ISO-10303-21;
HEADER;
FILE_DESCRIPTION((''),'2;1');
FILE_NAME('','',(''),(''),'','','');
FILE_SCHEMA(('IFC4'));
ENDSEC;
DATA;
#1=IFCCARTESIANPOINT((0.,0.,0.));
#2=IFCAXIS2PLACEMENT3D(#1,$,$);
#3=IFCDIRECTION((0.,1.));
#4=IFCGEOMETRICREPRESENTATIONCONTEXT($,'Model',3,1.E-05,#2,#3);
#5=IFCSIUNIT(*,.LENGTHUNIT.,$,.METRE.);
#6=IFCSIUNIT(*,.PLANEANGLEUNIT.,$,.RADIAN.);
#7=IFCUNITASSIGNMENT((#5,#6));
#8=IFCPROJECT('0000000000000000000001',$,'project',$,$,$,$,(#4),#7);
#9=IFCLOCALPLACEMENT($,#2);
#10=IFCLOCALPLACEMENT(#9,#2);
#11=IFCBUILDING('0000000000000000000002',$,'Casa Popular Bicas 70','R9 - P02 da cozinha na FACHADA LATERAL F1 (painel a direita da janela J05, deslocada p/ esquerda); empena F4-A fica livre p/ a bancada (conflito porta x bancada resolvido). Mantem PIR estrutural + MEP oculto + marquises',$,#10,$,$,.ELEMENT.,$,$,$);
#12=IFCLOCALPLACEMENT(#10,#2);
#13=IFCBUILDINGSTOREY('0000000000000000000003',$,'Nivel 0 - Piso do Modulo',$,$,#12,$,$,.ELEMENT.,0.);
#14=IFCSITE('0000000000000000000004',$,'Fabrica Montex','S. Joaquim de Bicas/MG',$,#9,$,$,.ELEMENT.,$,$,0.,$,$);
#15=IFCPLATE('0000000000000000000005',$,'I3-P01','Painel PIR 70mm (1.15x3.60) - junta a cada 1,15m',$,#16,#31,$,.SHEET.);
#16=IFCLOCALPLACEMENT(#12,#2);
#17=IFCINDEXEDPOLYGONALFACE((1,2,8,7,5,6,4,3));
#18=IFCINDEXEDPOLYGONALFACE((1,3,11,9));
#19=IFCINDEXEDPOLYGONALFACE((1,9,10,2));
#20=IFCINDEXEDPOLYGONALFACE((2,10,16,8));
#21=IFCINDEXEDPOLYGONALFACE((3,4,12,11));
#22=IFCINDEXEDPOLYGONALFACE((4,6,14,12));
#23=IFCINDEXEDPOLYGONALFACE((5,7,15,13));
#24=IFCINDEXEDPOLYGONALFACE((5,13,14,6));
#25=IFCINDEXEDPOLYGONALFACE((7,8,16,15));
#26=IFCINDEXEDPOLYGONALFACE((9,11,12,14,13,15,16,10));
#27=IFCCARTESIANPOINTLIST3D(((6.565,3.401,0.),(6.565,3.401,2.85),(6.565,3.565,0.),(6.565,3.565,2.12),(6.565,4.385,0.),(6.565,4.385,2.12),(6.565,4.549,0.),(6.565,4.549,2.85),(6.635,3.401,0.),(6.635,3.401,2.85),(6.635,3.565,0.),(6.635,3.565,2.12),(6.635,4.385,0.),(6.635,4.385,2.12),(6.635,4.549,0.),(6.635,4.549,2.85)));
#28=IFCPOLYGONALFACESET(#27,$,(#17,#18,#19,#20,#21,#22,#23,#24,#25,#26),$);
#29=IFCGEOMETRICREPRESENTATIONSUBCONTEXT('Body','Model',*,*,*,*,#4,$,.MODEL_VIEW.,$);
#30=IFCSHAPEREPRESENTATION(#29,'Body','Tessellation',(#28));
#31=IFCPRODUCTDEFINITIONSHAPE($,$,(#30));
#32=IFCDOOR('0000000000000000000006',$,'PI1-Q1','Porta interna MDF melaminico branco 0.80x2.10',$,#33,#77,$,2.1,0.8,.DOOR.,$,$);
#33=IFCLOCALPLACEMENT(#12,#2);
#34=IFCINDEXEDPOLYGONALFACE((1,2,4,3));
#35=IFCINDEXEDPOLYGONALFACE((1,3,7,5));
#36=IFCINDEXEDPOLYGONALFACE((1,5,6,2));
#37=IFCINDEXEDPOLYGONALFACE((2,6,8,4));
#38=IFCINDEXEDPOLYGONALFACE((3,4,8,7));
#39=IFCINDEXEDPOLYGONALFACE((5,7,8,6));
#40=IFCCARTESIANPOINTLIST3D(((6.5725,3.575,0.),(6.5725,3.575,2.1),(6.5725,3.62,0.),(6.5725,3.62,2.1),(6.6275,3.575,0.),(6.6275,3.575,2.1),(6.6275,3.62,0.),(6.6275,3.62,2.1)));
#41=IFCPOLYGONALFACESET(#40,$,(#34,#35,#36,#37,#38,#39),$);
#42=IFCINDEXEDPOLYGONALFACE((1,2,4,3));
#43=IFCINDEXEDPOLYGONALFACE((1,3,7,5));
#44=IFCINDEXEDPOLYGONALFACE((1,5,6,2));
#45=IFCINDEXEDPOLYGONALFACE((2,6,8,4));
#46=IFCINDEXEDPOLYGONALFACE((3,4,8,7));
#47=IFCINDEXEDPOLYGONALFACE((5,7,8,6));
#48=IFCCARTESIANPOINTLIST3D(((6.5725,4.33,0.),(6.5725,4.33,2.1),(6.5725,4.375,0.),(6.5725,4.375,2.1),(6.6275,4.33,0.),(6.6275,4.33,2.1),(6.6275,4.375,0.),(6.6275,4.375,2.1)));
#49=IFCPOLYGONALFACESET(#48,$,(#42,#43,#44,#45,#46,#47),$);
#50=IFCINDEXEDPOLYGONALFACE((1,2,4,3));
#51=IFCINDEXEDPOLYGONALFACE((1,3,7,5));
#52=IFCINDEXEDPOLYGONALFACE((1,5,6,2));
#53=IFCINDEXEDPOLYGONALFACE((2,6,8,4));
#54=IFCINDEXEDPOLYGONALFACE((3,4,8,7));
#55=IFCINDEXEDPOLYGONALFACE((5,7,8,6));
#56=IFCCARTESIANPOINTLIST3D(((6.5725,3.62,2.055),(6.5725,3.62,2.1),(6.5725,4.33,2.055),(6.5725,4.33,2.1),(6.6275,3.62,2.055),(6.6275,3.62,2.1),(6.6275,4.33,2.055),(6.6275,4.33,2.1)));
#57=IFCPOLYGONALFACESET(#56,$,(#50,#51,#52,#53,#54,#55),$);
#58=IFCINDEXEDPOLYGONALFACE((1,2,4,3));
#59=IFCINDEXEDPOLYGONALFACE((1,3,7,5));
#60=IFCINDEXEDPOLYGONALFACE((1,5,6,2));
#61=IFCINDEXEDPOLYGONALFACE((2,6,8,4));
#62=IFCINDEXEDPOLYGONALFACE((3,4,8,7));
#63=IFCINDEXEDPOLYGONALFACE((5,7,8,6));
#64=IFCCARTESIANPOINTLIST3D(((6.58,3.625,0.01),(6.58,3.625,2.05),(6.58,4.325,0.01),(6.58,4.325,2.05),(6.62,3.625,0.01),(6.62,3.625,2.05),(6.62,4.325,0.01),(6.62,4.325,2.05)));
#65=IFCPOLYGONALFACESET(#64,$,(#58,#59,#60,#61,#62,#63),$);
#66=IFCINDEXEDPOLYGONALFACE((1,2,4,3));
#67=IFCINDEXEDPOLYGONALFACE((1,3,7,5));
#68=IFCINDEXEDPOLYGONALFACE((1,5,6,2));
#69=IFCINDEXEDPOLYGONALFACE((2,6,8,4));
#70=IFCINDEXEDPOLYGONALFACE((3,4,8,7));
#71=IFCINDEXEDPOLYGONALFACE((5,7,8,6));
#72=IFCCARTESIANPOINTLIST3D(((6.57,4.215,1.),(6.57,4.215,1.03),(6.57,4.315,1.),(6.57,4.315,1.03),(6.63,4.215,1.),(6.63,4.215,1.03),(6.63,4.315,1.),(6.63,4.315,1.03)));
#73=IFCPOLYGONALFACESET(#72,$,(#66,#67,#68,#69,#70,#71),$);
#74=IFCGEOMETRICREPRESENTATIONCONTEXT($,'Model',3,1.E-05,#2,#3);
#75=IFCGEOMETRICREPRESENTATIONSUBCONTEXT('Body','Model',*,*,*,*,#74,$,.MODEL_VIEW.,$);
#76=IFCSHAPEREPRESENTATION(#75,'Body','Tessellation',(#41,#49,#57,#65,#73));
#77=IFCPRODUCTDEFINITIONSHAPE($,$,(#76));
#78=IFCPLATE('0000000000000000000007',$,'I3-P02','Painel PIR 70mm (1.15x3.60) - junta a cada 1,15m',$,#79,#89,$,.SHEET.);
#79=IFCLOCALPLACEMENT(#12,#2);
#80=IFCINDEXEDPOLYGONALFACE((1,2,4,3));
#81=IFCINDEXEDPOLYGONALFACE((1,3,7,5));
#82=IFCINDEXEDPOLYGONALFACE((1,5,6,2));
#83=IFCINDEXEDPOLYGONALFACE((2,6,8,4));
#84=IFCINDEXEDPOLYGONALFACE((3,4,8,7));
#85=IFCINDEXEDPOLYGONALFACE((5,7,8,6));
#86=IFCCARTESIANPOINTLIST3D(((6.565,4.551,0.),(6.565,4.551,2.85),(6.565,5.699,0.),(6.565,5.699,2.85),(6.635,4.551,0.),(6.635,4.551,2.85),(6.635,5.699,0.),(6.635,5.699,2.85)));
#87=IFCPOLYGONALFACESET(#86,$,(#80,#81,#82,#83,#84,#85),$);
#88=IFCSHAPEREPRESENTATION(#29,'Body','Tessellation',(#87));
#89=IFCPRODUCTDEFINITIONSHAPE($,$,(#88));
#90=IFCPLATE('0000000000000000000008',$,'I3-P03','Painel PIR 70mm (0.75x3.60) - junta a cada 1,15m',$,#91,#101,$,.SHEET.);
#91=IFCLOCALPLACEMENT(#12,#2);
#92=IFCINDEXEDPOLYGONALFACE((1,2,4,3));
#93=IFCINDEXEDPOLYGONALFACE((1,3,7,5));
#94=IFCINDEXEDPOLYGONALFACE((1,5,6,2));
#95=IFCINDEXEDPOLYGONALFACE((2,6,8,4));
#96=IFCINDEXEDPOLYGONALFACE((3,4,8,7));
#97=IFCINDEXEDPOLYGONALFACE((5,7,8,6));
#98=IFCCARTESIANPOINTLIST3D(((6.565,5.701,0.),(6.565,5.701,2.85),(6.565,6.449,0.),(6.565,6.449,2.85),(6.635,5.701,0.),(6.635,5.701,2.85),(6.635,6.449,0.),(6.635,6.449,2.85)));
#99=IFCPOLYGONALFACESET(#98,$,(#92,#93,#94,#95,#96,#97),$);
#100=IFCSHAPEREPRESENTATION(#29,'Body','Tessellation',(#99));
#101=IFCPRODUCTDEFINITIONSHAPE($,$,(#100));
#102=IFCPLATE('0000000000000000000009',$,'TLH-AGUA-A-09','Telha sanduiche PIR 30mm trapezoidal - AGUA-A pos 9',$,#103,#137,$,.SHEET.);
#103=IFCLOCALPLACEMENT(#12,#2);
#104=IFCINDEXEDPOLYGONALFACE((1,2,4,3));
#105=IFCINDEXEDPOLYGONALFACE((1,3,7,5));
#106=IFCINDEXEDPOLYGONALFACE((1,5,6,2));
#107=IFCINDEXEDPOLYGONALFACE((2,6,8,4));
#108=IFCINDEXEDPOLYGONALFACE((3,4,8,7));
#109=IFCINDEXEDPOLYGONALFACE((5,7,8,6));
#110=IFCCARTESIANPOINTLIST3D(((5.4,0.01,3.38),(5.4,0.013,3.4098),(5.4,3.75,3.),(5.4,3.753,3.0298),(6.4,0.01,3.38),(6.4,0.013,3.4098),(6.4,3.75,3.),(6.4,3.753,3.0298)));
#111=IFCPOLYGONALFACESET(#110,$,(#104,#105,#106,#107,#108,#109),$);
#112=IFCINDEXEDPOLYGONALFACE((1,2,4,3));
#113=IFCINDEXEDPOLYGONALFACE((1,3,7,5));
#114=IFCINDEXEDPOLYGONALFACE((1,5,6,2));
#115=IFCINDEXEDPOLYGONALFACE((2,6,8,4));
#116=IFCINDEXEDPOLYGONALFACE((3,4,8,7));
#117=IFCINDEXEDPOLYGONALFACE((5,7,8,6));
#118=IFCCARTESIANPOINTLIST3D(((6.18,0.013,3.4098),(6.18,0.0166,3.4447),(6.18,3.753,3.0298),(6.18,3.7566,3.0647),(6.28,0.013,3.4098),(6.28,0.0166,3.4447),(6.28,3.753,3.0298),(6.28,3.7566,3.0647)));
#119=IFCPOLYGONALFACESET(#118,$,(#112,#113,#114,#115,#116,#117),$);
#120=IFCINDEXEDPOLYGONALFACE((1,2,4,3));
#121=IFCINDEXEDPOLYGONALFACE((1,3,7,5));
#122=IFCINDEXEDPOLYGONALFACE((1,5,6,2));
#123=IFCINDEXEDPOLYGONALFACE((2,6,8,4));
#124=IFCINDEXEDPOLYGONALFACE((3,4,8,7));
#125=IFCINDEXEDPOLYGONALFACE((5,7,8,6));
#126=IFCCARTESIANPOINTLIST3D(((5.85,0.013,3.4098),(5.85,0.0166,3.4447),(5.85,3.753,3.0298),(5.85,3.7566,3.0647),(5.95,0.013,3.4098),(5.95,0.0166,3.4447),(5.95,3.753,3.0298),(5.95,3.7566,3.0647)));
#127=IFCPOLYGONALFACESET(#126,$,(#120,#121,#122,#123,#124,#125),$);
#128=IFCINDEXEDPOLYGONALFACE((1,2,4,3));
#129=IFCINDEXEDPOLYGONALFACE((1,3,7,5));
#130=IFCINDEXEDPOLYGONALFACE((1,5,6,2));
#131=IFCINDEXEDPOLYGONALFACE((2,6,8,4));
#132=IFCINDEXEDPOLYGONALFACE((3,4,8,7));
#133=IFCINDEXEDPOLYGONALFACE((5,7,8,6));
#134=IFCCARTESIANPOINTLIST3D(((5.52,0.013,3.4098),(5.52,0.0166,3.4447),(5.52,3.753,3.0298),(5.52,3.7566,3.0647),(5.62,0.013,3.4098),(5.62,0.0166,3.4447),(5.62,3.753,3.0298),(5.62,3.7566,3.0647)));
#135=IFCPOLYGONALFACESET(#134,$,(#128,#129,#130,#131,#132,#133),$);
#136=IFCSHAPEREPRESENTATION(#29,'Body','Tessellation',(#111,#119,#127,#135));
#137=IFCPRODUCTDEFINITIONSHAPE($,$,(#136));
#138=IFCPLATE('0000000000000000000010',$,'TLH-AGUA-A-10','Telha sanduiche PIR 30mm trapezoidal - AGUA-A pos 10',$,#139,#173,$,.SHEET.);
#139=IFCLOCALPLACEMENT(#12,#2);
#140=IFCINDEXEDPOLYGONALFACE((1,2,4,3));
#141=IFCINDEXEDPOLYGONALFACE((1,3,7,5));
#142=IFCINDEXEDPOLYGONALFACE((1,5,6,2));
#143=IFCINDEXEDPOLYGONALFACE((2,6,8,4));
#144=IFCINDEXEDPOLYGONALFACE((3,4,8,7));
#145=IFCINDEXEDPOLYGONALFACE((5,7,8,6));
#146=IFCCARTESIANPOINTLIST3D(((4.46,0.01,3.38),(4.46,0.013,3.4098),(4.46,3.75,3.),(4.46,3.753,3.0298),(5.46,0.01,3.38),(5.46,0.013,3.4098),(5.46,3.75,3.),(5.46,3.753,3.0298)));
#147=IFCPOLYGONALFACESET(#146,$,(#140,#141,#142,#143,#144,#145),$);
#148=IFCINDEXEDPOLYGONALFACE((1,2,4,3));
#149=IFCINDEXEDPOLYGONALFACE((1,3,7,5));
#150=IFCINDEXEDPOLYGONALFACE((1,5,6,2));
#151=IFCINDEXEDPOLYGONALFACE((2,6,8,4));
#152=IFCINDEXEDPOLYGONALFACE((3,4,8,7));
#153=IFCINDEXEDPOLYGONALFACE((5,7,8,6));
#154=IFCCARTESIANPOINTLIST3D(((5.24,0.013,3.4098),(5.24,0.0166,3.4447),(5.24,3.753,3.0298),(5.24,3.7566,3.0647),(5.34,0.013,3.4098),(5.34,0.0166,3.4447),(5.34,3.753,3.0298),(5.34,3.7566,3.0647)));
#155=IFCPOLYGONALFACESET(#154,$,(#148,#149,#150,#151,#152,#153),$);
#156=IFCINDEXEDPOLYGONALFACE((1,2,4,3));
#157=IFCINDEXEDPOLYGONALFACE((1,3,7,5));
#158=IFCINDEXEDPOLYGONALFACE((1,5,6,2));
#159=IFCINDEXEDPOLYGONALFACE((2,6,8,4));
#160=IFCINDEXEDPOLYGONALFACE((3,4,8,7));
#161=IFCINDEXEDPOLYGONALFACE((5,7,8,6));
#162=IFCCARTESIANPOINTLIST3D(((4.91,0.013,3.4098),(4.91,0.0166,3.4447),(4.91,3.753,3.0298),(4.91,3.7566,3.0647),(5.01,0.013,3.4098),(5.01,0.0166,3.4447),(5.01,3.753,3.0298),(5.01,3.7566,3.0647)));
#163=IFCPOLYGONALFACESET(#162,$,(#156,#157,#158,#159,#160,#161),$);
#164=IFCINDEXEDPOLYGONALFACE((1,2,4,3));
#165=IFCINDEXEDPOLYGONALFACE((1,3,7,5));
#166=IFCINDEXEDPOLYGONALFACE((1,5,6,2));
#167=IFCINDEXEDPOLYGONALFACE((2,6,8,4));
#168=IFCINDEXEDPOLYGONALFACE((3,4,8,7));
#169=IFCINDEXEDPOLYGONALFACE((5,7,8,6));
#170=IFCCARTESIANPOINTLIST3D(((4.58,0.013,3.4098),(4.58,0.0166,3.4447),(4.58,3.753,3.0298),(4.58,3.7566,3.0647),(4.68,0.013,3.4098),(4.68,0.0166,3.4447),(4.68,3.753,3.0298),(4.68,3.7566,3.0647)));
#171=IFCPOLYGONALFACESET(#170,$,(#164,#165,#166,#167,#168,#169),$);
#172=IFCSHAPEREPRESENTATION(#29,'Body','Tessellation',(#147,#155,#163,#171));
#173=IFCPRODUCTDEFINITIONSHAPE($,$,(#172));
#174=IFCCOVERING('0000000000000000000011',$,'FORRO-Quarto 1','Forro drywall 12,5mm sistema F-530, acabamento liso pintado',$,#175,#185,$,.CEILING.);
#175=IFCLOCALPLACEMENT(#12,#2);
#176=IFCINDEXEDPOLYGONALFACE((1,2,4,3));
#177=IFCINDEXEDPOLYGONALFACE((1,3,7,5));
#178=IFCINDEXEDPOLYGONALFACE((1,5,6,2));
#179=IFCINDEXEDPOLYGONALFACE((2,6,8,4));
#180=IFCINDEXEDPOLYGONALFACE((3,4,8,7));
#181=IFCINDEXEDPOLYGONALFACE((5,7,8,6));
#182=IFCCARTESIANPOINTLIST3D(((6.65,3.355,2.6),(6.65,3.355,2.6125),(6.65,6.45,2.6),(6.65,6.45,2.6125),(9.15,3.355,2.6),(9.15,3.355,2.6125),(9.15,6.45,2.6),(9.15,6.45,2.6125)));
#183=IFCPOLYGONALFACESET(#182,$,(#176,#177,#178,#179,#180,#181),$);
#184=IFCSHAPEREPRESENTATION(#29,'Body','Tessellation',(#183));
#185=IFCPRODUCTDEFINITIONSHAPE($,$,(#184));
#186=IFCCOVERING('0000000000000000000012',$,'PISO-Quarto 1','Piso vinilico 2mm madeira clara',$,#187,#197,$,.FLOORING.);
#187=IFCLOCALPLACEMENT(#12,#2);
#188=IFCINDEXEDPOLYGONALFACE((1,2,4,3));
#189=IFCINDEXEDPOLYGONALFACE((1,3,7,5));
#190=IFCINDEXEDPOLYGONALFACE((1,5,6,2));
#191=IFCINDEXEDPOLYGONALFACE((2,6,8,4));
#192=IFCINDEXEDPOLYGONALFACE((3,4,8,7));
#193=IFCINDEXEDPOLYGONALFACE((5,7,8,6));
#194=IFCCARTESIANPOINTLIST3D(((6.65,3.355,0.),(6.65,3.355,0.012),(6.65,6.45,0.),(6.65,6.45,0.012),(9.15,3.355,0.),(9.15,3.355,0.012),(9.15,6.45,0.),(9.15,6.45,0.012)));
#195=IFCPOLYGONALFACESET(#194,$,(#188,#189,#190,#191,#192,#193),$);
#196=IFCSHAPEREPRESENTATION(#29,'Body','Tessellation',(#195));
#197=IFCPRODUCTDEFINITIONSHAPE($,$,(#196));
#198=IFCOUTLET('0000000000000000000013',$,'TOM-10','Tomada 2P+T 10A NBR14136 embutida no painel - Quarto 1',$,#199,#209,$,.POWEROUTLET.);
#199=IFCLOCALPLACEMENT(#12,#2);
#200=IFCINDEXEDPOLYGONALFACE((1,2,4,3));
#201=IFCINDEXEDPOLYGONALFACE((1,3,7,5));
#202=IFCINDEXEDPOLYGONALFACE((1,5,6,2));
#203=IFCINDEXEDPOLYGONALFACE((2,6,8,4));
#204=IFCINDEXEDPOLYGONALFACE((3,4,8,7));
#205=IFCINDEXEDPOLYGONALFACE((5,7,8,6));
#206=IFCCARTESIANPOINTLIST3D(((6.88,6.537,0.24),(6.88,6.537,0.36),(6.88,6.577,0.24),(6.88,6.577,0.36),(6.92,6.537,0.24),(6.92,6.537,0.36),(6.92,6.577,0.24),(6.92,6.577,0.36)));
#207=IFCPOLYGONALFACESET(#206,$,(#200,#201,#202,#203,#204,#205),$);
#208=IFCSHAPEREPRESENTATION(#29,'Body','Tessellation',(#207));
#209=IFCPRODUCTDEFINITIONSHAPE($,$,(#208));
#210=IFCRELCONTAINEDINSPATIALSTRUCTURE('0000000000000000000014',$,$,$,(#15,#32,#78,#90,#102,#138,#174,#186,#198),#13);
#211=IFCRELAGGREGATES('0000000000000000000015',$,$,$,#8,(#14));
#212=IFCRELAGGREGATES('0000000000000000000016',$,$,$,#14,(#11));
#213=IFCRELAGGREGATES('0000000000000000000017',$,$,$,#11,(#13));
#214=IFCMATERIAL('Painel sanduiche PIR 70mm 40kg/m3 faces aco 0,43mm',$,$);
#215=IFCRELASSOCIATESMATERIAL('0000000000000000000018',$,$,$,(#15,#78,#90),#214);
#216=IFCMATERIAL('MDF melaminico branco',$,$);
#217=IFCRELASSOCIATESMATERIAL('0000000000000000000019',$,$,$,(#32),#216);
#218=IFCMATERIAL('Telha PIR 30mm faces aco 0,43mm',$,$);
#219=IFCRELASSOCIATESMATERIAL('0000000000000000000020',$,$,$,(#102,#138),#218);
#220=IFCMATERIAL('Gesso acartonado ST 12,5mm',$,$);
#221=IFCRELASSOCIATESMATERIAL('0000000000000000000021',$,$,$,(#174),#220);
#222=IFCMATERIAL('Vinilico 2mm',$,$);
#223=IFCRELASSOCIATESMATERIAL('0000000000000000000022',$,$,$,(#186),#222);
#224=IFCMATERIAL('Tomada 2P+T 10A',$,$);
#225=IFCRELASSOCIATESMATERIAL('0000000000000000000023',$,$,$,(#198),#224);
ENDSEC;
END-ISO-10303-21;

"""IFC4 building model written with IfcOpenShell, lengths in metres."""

from ifc_helpers import new_model, si_unit, direction, frame, frame_2d, origin, place, context, subcontext, project, spatial, rectangle, extrude, material, element, fill, save


model = new_model("IFC4")

# Units and contexts
model_context_1 = context("Model", 3, precision=1e-05, world=origin(), true_north=direction((0.0, 1.0)))
model_context_2 = context("Model", 3, precision=1e-05, world=origin(), true_north=direction((0.0, 1.0)))
model_context_3 = context("Model", 3, precision=1e-05, world=origin(), true_north=direction((0.0, 1.0)))
body_context_1 = subcontext(model_context_1, "Body", "Model", "MODEL_VIEW")
body_context_2 = subcontext(model_context_2, "Body", "Model", "MODEL_VIEW")
body_context_3 = subcontext(model_context_3, "Body", "Model", "MODEL_VIEW")
ifc_project = project(units=[si_unit("LENGTHUNIT", "METRE"), si_unit("PLANEANGLEUNIT", "RADIAN")], contexts=[model_context_1])

# Site, building, storey
site_placement = place(None, origin())
site = spatial("IfcSite", under=ifc_project, at=site_placement, Name="Fabrica Montex", Description="S. Joaquim de Bicas/MG", CompositionType="ELEMENT", RefElevation=0.0)
building_placement = place(site_placement, origin())
building = spatial("IfcBuilding", under=site, at=building_placement, Name="Casa Popular Bicas 70", Description="R9 - P02 da cozinha na FACHADA LATERAL F1 (painel a direita da janela J05, deslocada p/ esquerda); empena F4-A fica livre p/ a bancada (conflito porta x bancada resolvido). Mantem PIR estrutural + MEP oculto + marquises", CompositionType="ELEMENT")
storey_placement = place(building_placement, origin())
storey = spatial("IfcBuildingStorey", under=building, at=storey_placement, Name="Nivel 0 - Piso do Modulo", CompositionType="ELEMENT", Elevation=0.0)

# Shared definitions
ifc_material_1 = material(Name="Painel sanduiche PIR 70mm 40kg/m3 faces aco 0,43mm")

# Plate, opening, door
plate_1_placement = place(storey_placement, frame((6.6, 3.401, 0.0), x_axis=(0.0, 1.0, 0.0)))
plate_1 = element("IfcPlate", 1, at=plate_1_placement, inside=storey, material=ifc_material_1, Name="I3-P01", Description="Painel PIR 70mm (1.15x3.60) - junta a cada 1,15m", PredefinedType="SHEET", context=body_context_1, shape_type="SweptSolid", body=[
    extrude(rectangle(XDim=1.148, YDim=0.07, at=frame_2d((0.574, 0.0))), origin(), (0.0, 0.0, 1.0), 2.85),
])
placement_1 = place(None, origin())
placement_2 = place(placement_1, origin())
placement_3 = place(placement_2, origin())
opening_1_placement = place(placement_3, frame((6.6, 3.575, 0.0), x_axis=(0.0, 1.0, 0.0)))
opening_1 = element("IfcOpeningElement", 2, at=opening_1_placement, cuts=plate_1, PredefinedType="OPENING", context=body_context_3, shape_type="SweptSolid", body=[
    extrude(rectangle(XDim=0.82, YDim=0.3, at=frame_2d((0.4, 0.0))), origin(), (0.0, 0.0, 1.0), 2.12),
])
ifc_material_2 = material(Name="MDF melaminico branco")
placement_4 = place(None, origin())
placement_5 = place(placement_4, origin())
placement_6 = place(placement_5, origin())
door_placement = place(placement_6, frame((6.6, 3.575, 0.0), x_axis=(0.0, 1.0, 0.0)))
door = element("IfcDoor", 3, at=door_placement, inside=storey, material=ifc_material_2, Name="PI1-Q1", Description="Porta interna MDF melaminico branco 0.80x2.10", OverallHeight=2.1, OverallWidth=0.8, PredefinedType="DOOR", context=body_context_2, shape_type="SweptSolid", body=[
    extrude(rectangle(XDim=0.045, YDim=0.055, at=frame_2d((0.0225, 0.0))), origin(), (0.0, 0.0, 1.0), 2.1),
    extrude(rectangle(XDim=0.045, YDim=0.055, at=frame_2d((0.7775, 0.0))), origin(), (0.0, 0.0, 1.0), 2.1),
    extrude(rectangle(XDim=0.71, YDim=0.055, at=frame_2d((0.4, 0.0))), frame((0.0, 0.0, 2.055)), (0.0, 0.0, 1.0), 0.045),
    extrude(rectangle(XDim=0.7, YDim=0.04, at=frame_2d((0.4, 0.0))), frame((0.0, 0.0, 0.01)), (0.0, 0.0, 1.0), 2.04),
    extrude(rectangle(XDim=0.1, YDim=0.06, at=frame_2d((0.69, 0.0))), frame((0.0, 0.0, 1.0)), (0.0, 0.0, 1.0), 0.03),
])
fill(opening_1, door)

# Plates
plate_2_placement = place(storey_placement, frame((6.6, 4.551, 0.0), x_axis=(0.0, 1.0, 0.0)))
element("IfcPlate", 4, at=plate_2_placement, inside=storey, material=ifc_material_1, Name="I3-P02", Description="Painel PIR 70mm (1.15x3.60) - junta a cada 1,15m", PredefinedType="SHEET", context=body_context_1, shape_type="SweptSolid", body=[
    extrude(rectangle(XDim=1.148, YDim=0.07, at=frame_2d((0.574, 0.0))), origin(), (0.0, 0.0, 1.0), 2.85),
])
plate_3_placement = place(storey_placement, frame((6.6, 5.701, 0.0), x_axis=(0.0, 1.0, 0.0)))
element("IfcPlate", 5, at=plate_3_placement, inside=storey, material=ifc_material_1, Name="I3-P03", Description="Painel PIR 70mm (0.75x3.60) - junta a cada 1,15m", PredefinedType="SHEET", context=body_context_1, shape_type="SweptSolid", body=[
    extrude(rectangle(XDim=0.748, YDim=0.07, at=frame_2d((0.374, 0.0))), origin(), (0.0, 0.0, 1.0), 2.85),
])
ifc_material_3 = material(Name="Telha PIR 30mm faces aco 0,43mm")
for number, where, z_axis, x_axis, name, description in (
    (6, (6.4, 3.75, 3.0), (0.0, 0.101084, 0.994878), (-1.0, 0.0, 0.0), "TLH-AGUA-A-09", "Telha sanduiche PIR 30mm trapezoidal - AGUA-A pos 9"),
    (7, (5.46, 3.75, 3.0), (0.0, 0.101084, 0.994878), (-1.0, 0.0, 0.0), "TLH-AGUA-A-10", "Telha sanduiche PIR 30mm trapezoidal - AGUA-A pos 10"),
):
    element("IfcPlate", number, at=place(None, frame(where, z_axis=z_axis, x_axis=x_axis)), inside=storey, material=ifc_material_3, Name=name, Description=description, PredefinedType="SHEET", context=body_context_1, shape_type="SweptSolid", body=[
        extrude(rectangle(XDim=1.0, YDim=3.7593, at=frame_2d((0.5, 1.8796))), origin(), (0.0, 0.0, 1.0), 0.03),
        extrude(rectangle(XDim=0.1, YDim=3.7593, at=frame_2d((0.17, 1.8796))), frame((0.0, 0.0, 0.03)), (0.0, 0.0, 1.0), 0.035),
        extrude(rectangle(XDim=0.1, YDim=3.7593, at=frame_2d((0.5, 1.8796))), frame((0.0, 0.0, 0.03)), (0.0, 0.0, 1.0), 0.035),
        extrude(rectangle(XDim=0.1, YDim=3.7593, at=frame_2d((0.83, 1.8796))), frame((0.0, 0.0, 0.03)), (0.0, 0.0, 1.0), 0.035),
    ])

# Coverings
ifc_material_4 = material(Name="Gesso acartonado ST 12,5mm")
covering_1_placement = place(storey_placement, frame((6.65, 3.355, 2.6)))
element("IfcCovering", 8, at=covering_1_placement, inside=storey, material=ifc_material_4, Name="FORRO-Quarto 1", Description="Forro drywall 12,5mm sistema F-530, acabamento liso pintado", PredefinedType="CEILING", context=body_context_1, shape_type="SweptSolid", body=[
    extrude(rectangle(XDim=2.5, YDim=3.095, at=frame_2d((1.25, 1.5475))), origin(), (0.0, 0.0, 1.0), 0.0125),
])
ifc_material_5 = material(Name="Vinilico 2mm")
covering_2_placement = place(storey_placement, frame((6.65, 3.355, 0.0)))
element("IfcCovering", 9, at=covering_2_placement, inside=storey, material=ifc_material_5, Name="PISO-Quarto 1", Description="Piso vinilico 2mm madeira clara", PredefinedType="FLOORING", context=body_context_1, shape_type="SweptSolid", body=[
    extrude(rectangle(XDim=2.5, YDim=3.095, at=frame_2d((1.25, 1.5475))), origin(), (0.0, 0.0, 1.0), 0.012),
])

# Outlet
ifc_material_6 = material(Name="Tomada 2P+T 10A")
outlet_1_placement = place(storey_placement, frame((6.88, 6.537, 0.24)))
element("IfcOutlet", 10, at=outlet_1_placement, inside=storey, material=ifc_material_6, Name="TOM-10", Description="Tomada 2P+T 10A NBR14136 embutida no painel - Quarto 1", PredefinedType="POWEROUTLET", context=body_context_1, shape_type="SweptSolid", body=[
    extrude(rectangle(XDim=0.04, YDim=0.04, at=frame_2d((0.02, 0.02))), origin(), (0.0, 0.0, 1.0), 0.12),
])

save(model, "model.ifc")
